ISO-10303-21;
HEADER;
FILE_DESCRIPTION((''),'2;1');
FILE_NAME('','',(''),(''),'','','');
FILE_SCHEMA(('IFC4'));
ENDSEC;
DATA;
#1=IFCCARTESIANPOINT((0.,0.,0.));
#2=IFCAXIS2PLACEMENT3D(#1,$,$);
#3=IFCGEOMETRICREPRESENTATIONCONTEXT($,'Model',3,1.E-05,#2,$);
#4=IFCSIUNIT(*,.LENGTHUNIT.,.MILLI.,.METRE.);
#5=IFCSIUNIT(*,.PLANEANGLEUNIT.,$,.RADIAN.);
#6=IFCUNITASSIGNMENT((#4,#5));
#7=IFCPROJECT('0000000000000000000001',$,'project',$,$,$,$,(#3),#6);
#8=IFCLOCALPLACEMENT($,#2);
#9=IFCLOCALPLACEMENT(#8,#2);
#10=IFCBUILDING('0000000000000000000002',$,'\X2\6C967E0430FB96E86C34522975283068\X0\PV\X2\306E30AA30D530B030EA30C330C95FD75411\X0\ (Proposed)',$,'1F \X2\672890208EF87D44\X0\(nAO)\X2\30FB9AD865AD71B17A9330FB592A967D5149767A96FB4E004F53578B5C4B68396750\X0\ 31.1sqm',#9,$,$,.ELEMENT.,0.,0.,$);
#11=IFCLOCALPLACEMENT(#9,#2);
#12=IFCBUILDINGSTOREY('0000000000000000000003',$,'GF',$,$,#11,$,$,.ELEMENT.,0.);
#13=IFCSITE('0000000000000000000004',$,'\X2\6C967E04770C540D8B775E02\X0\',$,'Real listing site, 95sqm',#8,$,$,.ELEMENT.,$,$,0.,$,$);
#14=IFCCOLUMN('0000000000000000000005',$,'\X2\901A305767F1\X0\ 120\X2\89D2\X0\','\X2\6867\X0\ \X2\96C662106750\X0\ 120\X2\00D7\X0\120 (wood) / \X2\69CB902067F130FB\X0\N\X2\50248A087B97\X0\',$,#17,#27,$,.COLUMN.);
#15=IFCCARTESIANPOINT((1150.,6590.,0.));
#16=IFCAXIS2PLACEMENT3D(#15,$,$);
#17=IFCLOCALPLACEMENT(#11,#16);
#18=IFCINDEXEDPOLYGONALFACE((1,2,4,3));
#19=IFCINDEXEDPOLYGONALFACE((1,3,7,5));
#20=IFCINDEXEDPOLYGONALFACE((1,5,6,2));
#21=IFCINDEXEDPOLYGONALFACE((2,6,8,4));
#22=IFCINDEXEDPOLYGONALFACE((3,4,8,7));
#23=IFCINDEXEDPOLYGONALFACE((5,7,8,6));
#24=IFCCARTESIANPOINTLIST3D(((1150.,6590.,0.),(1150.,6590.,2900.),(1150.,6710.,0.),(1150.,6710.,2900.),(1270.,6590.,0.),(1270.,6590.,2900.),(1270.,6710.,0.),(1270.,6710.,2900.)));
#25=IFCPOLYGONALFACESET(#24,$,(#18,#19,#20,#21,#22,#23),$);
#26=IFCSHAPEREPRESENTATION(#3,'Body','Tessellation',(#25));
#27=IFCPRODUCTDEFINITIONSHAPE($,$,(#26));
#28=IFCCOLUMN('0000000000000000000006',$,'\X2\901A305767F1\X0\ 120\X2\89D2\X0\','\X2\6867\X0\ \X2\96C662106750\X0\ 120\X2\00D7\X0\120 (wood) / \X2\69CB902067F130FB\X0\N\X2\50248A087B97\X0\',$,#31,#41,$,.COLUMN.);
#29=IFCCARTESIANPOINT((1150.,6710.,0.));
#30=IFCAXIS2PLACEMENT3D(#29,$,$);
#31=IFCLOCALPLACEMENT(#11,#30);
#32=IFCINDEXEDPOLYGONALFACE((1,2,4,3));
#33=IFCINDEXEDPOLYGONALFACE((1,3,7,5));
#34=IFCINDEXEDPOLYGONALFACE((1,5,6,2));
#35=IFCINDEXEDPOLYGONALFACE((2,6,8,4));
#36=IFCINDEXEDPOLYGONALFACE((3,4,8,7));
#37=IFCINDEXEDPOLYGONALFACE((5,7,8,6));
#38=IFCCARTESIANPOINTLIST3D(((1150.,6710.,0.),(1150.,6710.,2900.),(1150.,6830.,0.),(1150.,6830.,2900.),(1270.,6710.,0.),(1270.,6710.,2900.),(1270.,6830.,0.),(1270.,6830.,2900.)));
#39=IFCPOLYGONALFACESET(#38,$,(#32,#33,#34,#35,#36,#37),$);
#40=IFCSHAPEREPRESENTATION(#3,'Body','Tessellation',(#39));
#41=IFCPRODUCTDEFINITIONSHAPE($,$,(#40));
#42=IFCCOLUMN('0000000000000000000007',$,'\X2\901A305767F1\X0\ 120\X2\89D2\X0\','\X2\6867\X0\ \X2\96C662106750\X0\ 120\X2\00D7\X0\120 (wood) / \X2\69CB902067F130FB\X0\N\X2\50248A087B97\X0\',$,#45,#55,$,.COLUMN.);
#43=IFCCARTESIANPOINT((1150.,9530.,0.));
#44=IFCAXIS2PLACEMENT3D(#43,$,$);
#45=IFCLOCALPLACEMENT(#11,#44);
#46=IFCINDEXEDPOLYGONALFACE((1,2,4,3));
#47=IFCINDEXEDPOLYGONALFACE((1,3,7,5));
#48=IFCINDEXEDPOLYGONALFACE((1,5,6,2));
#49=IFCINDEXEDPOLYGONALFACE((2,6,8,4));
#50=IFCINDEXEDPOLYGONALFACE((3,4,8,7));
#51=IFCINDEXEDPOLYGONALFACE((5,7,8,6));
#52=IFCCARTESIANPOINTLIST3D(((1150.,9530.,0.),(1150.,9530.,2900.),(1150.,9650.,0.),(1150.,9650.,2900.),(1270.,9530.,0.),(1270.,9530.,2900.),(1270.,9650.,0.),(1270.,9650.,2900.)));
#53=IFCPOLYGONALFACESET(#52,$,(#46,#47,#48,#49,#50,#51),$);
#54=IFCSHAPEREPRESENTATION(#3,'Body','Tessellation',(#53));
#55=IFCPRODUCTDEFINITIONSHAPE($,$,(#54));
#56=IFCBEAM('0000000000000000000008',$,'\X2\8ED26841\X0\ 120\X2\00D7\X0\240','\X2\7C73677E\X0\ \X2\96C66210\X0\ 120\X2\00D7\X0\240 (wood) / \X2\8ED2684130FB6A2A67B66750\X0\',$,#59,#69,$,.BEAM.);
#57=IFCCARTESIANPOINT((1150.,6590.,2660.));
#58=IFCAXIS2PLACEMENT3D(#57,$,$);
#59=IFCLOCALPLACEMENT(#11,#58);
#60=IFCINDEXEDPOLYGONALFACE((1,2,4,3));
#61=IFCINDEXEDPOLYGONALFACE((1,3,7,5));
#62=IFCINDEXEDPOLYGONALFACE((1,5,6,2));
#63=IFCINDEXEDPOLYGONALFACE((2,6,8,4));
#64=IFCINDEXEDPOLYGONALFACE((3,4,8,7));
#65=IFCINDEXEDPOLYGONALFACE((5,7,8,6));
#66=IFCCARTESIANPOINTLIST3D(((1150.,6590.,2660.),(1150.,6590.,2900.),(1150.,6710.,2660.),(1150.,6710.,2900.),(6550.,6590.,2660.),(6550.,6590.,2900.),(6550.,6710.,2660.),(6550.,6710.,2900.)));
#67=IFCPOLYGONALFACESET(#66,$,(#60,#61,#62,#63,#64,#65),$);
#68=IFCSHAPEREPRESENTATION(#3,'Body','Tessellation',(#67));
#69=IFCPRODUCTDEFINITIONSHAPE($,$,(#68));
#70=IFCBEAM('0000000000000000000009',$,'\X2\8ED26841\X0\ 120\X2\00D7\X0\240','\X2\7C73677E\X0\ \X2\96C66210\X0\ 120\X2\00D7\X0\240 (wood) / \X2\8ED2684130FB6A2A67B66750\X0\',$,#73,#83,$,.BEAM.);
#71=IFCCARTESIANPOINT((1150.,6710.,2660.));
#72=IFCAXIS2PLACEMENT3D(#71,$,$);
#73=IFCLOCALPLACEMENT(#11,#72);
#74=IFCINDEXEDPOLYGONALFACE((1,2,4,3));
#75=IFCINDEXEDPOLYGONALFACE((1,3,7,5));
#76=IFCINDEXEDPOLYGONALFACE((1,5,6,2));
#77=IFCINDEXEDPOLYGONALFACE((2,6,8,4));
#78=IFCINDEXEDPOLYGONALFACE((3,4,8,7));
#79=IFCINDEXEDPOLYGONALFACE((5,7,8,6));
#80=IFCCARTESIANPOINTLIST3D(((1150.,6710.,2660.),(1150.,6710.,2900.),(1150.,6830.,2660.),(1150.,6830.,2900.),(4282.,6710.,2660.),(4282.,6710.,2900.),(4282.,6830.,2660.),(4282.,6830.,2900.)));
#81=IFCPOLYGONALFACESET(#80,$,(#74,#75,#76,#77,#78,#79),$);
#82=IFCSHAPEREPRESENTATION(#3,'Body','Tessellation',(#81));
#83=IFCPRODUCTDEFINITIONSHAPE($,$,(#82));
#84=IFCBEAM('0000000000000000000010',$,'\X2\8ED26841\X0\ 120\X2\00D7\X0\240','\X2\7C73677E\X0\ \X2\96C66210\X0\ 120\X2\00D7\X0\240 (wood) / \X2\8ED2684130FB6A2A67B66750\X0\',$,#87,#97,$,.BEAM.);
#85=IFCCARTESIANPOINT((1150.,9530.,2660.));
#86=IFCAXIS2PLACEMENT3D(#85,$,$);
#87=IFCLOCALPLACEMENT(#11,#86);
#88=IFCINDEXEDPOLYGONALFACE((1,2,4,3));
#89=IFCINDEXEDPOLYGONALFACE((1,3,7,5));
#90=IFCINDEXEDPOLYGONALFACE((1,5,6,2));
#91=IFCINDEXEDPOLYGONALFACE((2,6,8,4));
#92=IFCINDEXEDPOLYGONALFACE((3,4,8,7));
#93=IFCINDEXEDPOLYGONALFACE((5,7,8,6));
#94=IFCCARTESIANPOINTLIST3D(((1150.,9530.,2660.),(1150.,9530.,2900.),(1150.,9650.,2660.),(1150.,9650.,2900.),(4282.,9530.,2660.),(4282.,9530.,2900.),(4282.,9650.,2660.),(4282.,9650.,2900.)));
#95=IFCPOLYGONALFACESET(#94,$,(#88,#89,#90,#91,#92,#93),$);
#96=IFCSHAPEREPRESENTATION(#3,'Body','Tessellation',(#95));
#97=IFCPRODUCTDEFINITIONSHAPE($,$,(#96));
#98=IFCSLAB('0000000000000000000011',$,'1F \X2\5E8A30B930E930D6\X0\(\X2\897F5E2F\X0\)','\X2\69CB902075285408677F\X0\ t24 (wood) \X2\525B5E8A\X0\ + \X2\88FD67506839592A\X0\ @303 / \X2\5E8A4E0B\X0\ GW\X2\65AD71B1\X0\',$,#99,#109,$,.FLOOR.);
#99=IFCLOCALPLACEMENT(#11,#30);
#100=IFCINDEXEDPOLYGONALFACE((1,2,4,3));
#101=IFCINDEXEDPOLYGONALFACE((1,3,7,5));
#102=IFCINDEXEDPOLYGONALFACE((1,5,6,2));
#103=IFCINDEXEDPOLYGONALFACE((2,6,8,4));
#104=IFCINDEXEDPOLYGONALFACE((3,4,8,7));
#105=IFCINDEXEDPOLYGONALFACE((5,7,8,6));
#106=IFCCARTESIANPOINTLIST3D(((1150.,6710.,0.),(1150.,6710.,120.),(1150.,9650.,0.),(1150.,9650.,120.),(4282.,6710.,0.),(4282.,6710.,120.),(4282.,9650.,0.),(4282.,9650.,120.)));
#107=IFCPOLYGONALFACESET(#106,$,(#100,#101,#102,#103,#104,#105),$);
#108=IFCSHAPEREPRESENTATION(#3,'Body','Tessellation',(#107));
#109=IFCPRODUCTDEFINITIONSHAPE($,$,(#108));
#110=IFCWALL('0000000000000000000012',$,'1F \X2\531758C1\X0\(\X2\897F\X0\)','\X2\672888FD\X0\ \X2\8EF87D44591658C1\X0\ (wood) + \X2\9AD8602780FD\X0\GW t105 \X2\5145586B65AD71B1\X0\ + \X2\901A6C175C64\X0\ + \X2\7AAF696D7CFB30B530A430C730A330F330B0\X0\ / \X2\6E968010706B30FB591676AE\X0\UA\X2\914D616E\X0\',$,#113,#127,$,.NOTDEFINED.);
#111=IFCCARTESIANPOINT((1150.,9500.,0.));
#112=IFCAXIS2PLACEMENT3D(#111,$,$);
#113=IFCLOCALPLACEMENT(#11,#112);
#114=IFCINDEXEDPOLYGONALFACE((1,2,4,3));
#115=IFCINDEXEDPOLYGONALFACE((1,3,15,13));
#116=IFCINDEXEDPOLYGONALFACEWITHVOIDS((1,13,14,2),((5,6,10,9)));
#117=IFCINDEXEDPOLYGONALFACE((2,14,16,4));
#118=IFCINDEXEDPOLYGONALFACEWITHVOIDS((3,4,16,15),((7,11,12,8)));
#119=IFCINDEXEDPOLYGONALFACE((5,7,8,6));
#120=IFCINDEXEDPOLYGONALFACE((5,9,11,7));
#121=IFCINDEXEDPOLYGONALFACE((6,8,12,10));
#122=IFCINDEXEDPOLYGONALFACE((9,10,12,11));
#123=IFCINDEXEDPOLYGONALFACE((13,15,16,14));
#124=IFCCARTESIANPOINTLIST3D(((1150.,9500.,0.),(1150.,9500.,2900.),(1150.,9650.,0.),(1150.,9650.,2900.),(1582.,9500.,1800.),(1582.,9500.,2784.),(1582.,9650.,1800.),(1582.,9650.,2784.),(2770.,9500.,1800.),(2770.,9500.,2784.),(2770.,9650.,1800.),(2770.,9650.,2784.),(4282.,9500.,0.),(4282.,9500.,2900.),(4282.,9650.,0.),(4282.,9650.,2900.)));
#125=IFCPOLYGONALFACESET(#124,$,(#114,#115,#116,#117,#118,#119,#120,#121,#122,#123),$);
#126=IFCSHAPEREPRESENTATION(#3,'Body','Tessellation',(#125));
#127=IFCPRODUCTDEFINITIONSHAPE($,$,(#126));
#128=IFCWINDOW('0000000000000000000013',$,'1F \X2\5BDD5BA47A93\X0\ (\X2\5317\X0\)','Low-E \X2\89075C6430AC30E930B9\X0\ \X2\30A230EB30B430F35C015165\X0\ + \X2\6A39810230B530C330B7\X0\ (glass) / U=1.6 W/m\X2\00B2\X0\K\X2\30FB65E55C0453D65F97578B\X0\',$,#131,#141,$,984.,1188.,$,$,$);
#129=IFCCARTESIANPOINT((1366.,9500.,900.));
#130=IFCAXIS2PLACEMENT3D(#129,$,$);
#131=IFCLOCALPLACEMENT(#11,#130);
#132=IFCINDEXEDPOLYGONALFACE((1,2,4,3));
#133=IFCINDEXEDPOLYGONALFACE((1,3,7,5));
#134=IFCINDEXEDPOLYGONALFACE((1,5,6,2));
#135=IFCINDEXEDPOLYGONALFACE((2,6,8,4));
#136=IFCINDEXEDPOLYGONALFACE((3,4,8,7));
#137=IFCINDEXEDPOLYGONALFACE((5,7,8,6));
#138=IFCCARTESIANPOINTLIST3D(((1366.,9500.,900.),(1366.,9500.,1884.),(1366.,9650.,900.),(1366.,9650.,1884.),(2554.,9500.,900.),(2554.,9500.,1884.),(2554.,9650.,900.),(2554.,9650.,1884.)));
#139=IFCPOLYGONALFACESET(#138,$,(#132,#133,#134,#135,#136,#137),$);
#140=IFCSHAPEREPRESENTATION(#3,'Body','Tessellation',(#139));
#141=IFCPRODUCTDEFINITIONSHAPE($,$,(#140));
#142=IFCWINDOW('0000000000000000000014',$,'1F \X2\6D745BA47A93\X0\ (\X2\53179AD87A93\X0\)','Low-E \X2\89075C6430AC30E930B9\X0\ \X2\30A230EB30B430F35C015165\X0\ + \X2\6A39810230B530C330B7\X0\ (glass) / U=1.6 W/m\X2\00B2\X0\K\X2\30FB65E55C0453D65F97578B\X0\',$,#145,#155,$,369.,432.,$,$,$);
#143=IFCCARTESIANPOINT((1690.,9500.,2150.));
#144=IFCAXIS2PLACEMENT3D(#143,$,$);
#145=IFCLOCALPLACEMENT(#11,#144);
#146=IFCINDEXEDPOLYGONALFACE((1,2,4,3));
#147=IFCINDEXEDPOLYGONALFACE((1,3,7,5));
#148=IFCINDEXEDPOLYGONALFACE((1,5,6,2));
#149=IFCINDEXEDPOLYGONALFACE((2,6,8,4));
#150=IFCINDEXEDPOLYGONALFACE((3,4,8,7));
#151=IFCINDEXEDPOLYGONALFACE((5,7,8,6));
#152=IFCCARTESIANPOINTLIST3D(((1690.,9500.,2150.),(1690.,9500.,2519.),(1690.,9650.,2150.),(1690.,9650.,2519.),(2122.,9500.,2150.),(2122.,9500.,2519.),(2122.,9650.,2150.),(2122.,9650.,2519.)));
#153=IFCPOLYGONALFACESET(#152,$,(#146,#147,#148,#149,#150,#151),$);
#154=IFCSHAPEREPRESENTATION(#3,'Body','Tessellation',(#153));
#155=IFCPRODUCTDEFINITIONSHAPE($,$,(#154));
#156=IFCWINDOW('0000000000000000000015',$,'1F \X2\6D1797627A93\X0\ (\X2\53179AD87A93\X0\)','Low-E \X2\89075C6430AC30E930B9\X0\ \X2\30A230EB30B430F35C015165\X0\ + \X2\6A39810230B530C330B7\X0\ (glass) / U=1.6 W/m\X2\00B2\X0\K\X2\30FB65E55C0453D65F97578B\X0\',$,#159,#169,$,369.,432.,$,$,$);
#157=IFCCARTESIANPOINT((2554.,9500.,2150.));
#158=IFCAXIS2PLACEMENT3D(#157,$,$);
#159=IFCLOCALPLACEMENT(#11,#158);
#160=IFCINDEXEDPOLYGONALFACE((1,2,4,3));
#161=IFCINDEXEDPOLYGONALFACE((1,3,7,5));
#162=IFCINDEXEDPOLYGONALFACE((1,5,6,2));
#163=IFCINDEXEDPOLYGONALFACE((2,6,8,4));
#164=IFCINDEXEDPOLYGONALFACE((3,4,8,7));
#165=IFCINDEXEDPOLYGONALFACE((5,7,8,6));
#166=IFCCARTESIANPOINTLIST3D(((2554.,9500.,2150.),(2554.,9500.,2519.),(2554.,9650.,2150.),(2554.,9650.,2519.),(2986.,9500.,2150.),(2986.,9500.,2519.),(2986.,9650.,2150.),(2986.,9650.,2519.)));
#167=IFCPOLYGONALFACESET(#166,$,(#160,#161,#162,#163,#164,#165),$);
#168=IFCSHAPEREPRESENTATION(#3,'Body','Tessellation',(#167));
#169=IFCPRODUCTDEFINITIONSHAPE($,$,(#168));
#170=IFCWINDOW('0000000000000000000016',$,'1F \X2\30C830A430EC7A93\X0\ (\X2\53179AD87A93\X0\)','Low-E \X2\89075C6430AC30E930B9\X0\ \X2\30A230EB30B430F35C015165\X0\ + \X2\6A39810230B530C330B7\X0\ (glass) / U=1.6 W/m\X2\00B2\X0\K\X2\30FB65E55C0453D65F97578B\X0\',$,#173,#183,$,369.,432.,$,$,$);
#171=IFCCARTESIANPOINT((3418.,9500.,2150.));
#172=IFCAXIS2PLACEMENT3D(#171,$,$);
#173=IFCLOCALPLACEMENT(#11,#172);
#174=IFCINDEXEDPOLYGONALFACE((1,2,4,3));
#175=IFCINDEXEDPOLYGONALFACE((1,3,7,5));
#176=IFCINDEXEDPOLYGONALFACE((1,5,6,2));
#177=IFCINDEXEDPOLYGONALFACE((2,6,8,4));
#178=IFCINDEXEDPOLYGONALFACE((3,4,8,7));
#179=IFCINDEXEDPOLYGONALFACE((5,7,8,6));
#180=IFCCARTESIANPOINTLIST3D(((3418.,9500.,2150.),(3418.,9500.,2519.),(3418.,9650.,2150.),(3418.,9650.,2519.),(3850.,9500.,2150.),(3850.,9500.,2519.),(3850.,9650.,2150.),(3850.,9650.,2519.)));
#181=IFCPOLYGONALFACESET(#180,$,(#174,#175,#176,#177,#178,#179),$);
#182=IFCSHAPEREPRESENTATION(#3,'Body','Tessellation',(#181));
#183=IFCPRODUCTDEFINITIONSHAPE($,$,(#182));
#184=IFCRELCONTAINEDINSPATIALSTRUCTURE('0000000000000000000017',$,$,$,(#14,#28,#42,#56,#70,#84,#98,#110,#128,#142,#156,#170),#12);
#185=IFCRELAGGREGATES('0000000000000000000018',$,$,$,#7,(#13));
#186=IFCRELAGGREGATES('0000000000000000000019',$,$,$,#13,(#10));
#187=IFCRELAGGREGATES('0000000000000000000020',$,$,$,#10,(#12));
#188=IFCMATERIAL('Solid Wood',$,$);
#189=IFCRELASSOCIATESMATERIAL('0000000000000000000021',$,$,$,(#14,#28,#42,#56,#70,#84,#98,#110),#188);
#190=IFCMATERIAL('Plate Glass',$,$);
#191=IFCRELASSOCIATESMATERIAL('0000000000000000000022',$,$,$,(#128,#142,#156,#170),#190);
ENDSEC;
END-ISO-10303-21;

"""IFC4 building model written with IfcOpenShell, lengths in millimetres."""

from ifc_helpers import new_model, si_unit, frame, frame_2d, origin, place, context, project, spatial, rectangle, extrude, material, element, fill, save


model = new_model("IFC4")

# Units and contexts
model_context = context("Model", 3, precision=1e-05, world=origin())
ifc_project = project(units=[si_unit("LENGTHUNIT", "METRE", prefix="MILLI"), si_unit("PLANEANGLEUNIT", "RADIAN")], contexts=[model_context])

# Site, building, storey
site_placement = place(None, origin())
site = spatial("IfcSite", under=ifc_project, at=site_placement, Name="沖縄県名護市", ObjectType="Real listing site, 95sqm", CompositionType="ELEMENT", RefElevation=0.0)
building_placement = place(site_placement, origin())
building = spatial("IfcBuilding", under=site, at=building_placement, Name="沖縄・雨水利用とPVのオフグリッド志向 (Proposed)", ObjectType="1F 木造軸組(nAO)・高断熱窓・太陽光発電一体型屋根材 31.1sqm", CompositionType="ELEMENT", ElevationOfRefHeight=0.0, ElevationOfTerrain=0.0)
storey_placement = place(building_placement, origin())
storey = spatial("IfcBuildingStorey", under=building, at=storey_placement, Name="GF", CompositionType="ELEMENT", Elevation=0.0)

# Columns
ifc_material_1 = material(Name="Solid Wood")
column_1_placement = place(storey_placement, frame((1150.0, 6590.0, 0.0)))
element("IfcColumn", 1, at=column_1_placement, inside=storey, material=ifc_material_1, Name="通し柱 120角", Description="桧 集成材 120×120 (wood) / 構造柱・N値計算", PredefinedType="COLUMN", context=model_context, shape_type="SweptSolid", body=[
    extrude(rectangle(XDim=120.0, YDim=120.0, at=frame_2d((60.0, 60.0))), frame((1150.0, 6590.0, 0.0)), (0.0, 0.0, 1.0), 2900.0),
])
column_2_placement = place(storey_placement, frame((1150.0, 6710.0, 0.0)))
element("IfcColumn", 2, at=column_2_placement, inside=storey, material=ifc_material_1, Name="通し柱 120角", Description="桧 集成材 120×120 (wood) / 構造柱・N値計算", PredefinedType="COLUMN", context=model_context, shape_type="SweptSolid", body=[
    extrude(rectangle(XDim=120.0, YDim=120.0, at=frame_2d((60.0, 60.0))), frame((1150.0, 6710.0, 0.0)), (0.0, 0.0, 1.0), 2900.0),
])
column_3_placement = place(storey_placement, frame((1150.0, 9530.0, 0.0)))
element("IfcColumn", 3, at=column_3_placement, inside=storey, material=ifc_material_1, Name="通し柱 120角", Description="桧 集成材 120×120 (wood) / 構造柱・N値計算", PredefinedType="COLUMN", context=model_context, shape_type="SweptSolid", body=[
    extrude(rectangle(XDim=120.0, YDim=120.0, at=frame_2d((60.0, 60.0))), frame((1150.0, 9530.0, 0.0)), (0.0, 0.0, 1.0), 2900.0),
])

# Beams
beam_1_placement = place(storey_placement, frame((1150.0, 6590.0, 2660.0)))
element("IfcBeam", 4, at=beam_1_placement, inside=storey, material=ifc_material_1, Name="軒桁 120×240", Description="米松 集成 120×240 (wood) / 軒桁・横架材", PredefinedType="BEAM", context=model_context, shape_type="SweptSolid", body=[
    extrude(rectangle(XDim=5400.0, YDim=120.0, at=frame_2d((2700.0, 60.0))), frame((1150.0, 6590.0, 2660.0)), (0.0, 0.0, 1.0), 240.0),
])
beam_2_placement = place(storey_placement, frame((1150.0, 6710.0, 2660.0)))
element("IfcBeam", 5, at=beam_2_placement, inside=storey, material=ifc_material_1, Name="軒桁 120×240", Description="米松 集成 120×240 (wood) / 軒桁・横架材", PredefinedType="BEAM", context=model_context, shape_type="SweptSolid", body=[
    extrude(rectangle(XDim=3132.0, YDim=120.0, at=frame_2d((1566.0, 60.0))), frame((1150.0, 6710.0, 2660.0)), (0.0, 0.0, 1.0), 240.0),
])
beam_3_placement = place(storey_placement, frame((1150.0, 9530.0, 2660.0)))
element("IfcBeam", 6, at=beam_3_placement, inside=storey, material=ifc_material_1, Name="軒桁 120×240", Description="米松 集成 120×240 (wood) / 軒桁・横架材", PredefinedType="BEAM", context=model_context, shape_type="SweptSolid", body=[
    extrude(rectangle(XDim=3132.0, YDim=120.0, at=frame_2d((1566.0, 60.0))), frame((1150.0, 9530.0, 2660.0)), (0.0, 0.0, 1.0), 240.0),
])

# Slab
slab_placement = place(storey_placement, frame((1150.0, 6710.0, 0.0)))
element("IfcSlab", 7, at=slab_placement, inside=storey, material=ifc_material_1, Name="1F 床スラブ(西帯)", Description="構造用合板 t24 (wood) 剛床 + 製材根太 @303 / 床下 GW断熱", PredefinedType="FLOOR", context=model_context, shape_type="SweptSolid", body=[
    extrude(rectangle(XDim=3132.0, YDim=2940.0, at=frame_2d((1566.0, 1470.0))), frame((1150.0, 6710.0, 0.0)), (0.0, 0.0, 1.0), 120.0),
])

# Wall, openings, windows
wall_1_placement = place(storey_placement, frame((1150.0, 9500.0, 0.0)))
wall_1 = element("IfcWall", 8, at=wall_1_placement, inside=storey, material=ifc_material_1, Name="1F 北壁(西)", Description="木製 軸組外壁 (wood) + 高性能GW t105 充填断熱 + 通気層 + 窯業系サイディング / 準耐火・外皮UA配慮", PredefinedType="NOTDEFINED", context=model_context, shape_type="SweptSolid", body=[
    extrude(rectangle(XDim=3132.0, YDim=150.0, at=frame_2d((1566.0, 75.0))), frame((1150.0, 9500.0, 0.0)), (0.0, 0.0, 1.0), 2900.0),
])
opening_1_placement = place(storey_placement, frame((1366.0, 9500.0, 900.0)))
opening_1 = element("IfcOpeningElement", 9, at=opening_1_placement, cuts=wall_1, PredefinedType="NOTDEFINED", context=model_context, shape_type="SweptSolid", body=[
    extrude(rectangle(XDim=1188.0, YDim=150.0, at=frame_2d((594.0, 75.0))), frame((1366.0, 9500.0, 900.0)), (0.0, 0.0, 1.0), 984.0),
])
opening_2_placement = place(storey_placement, frame((1690.0, 9500.0, 2150.0)))
opening_2 = element("IfcOpeningElement", 10, at=opening_2_placement, cuts=wall_1, PredefinedType="NOTDEFINED", context=model_context, shape_type="SweptSolid", body=[
    extrude(rectangle(XDim=432.0, YDim=150.0, at=frame_2d((216.0, 75.0))), frame((1690.0, 9500.0, 2150.0)), (0.0, 0.0, 1.0), 369.0),
])
opening_3_placement = place(storey_placement, frame((2554.0, 9500.0, 2150.0)))
opening_3 = element("IfcOpeningElement", 11, at=opening_3_placement, cuts=wall_1, PredefinedType="NOTDEFINED", context=model_context, shape_type="SweptSolid", body=[
    extrude(rectangle(XDim=432.0, YDim=150.0, at=frame_2d((216.0, 75.0))), frame((2554.0, 9500.0, 2150.0)), (0.0, 0.0, 1.0), 369.0),
])
opening_4_placement = place(storey_placement, frame((3418.0, 9500.0, 2150.0)))
opening_4 = element("IfcOpeningElement", 12, at=opening_4_placement, cuts=wall_1, PredefinedType="NOTDEFINED", context=model_context, shape_type="SweptSolid", body=[
    extrude(rectangle(XDim=432.0, YDim=150.0, at=frame_2d((216.0, 75.0))), frame((3418.0, 9500.0, 2150.0)), (0.0, 0.0, 1.0), 369.0),
])
ifc_material_2 = material(Name="Plate Glass")
window_1_placement = place(storey_placement, frame((1366.0, 9500.0, 900.0)))
window_1 = element("IfcWindow", 13, at=window_1_placement, inside=storey, material=ifc_material_2, Name="1F 寝室窓 (北)", Description="Low-E 複層ガラス アルゴン封入 + 樹脂サッシ (glass) / U=1.6 W/m²K・日射取得型", OverallHeight=984.0, OverallWidth=1188.0, context=model_context, shape_type="SweptSolid", body=[
    extrude(rectangle(XDim=1188.0, YDim=150.0, at=frame_2d((594.0, 75.0))), frame((1366.0, 9500.0, 900.0)), (0.0, 0.0, 1.0), 984.0),
])
fill(opening_1, window_1)
window_2_placement = place(storey_placement, frame((1690.0, 9500.0, 2150.0)))
window_2 = element("IfcWindow", 14, at=window_2_placement, inside=storey, material=ifc_material_2, Name="1F 浴室窓 (北高窓)", Description="Low-E 複層ガラス アルゴン封入 + 樹脂サッシ (glass) / U=1.6 W/m²K・日射取得型", OverallHeight=369.0, OverallWidth=432.0, context=model_context, shape_type="SweptSolid", body=[
    extrude(rectangle(XDim=432.0, YDim=150.0, at=frame_2d((216.0, 75.0))), frame((1690.0, 9500.0, 2150.0)), (0.0, 0.0, 1.0), 369.0),
])
fill(opening_2, window_2)
window_3_placement = place(storey_placement, frame((2554.0, 9500.0, 2150.0)))
window_3 = element("IfcWindow", 15, at=window_3_placement, inside=storey, material=ifc_material_2, Name="1F 洗面窓 (北高窓)", Description="Low-E 複層ガラス アルゴン封入 + 樹脂サッシ (glass) / U=1.6 W/m²K・日射取得型", OverallHeight=369.0, OverallWidth=432.0, context=model_context, shape_type="SweptSolid", body=[
    extrude(rectangle(XDim=432.0, YDim=150.0, at=frame_2d((216.0, 75.0))), frame((2554.0, 9500.0, 2150.0)), (0.0, 0.0, 1.0), 369.0),
])
fill(opening_3, window_3)
window_4_placement = place(storey_placement, frame((3418.0, 9500.0, 2150.0)))
window_4 = element("IfcWindow", 16, at=window_4_placement, inside=storey, material=ifc_material_2, Name="1F トイレ窓 (北高窓)", Description="Low-E 複層ガラス アルゴン封入 + 樹脂サッシ (glass) / U=1.6 W/m²K・日射取得型", OverallHeight=369.0, OverallWidth=432.0, context=model_context, shape_type="SweptSolid", body=[
    extrude(rectangle(XDim=432.0, YDim=150.0, at=frame_2d((216.0, 75.0))), frame((3418.0, 9500.0, 2150.0)), (0.0, 0.0, 1.0), 369.0),
])
fill(opening_4, window_4)

save(model, "model.ifc")
